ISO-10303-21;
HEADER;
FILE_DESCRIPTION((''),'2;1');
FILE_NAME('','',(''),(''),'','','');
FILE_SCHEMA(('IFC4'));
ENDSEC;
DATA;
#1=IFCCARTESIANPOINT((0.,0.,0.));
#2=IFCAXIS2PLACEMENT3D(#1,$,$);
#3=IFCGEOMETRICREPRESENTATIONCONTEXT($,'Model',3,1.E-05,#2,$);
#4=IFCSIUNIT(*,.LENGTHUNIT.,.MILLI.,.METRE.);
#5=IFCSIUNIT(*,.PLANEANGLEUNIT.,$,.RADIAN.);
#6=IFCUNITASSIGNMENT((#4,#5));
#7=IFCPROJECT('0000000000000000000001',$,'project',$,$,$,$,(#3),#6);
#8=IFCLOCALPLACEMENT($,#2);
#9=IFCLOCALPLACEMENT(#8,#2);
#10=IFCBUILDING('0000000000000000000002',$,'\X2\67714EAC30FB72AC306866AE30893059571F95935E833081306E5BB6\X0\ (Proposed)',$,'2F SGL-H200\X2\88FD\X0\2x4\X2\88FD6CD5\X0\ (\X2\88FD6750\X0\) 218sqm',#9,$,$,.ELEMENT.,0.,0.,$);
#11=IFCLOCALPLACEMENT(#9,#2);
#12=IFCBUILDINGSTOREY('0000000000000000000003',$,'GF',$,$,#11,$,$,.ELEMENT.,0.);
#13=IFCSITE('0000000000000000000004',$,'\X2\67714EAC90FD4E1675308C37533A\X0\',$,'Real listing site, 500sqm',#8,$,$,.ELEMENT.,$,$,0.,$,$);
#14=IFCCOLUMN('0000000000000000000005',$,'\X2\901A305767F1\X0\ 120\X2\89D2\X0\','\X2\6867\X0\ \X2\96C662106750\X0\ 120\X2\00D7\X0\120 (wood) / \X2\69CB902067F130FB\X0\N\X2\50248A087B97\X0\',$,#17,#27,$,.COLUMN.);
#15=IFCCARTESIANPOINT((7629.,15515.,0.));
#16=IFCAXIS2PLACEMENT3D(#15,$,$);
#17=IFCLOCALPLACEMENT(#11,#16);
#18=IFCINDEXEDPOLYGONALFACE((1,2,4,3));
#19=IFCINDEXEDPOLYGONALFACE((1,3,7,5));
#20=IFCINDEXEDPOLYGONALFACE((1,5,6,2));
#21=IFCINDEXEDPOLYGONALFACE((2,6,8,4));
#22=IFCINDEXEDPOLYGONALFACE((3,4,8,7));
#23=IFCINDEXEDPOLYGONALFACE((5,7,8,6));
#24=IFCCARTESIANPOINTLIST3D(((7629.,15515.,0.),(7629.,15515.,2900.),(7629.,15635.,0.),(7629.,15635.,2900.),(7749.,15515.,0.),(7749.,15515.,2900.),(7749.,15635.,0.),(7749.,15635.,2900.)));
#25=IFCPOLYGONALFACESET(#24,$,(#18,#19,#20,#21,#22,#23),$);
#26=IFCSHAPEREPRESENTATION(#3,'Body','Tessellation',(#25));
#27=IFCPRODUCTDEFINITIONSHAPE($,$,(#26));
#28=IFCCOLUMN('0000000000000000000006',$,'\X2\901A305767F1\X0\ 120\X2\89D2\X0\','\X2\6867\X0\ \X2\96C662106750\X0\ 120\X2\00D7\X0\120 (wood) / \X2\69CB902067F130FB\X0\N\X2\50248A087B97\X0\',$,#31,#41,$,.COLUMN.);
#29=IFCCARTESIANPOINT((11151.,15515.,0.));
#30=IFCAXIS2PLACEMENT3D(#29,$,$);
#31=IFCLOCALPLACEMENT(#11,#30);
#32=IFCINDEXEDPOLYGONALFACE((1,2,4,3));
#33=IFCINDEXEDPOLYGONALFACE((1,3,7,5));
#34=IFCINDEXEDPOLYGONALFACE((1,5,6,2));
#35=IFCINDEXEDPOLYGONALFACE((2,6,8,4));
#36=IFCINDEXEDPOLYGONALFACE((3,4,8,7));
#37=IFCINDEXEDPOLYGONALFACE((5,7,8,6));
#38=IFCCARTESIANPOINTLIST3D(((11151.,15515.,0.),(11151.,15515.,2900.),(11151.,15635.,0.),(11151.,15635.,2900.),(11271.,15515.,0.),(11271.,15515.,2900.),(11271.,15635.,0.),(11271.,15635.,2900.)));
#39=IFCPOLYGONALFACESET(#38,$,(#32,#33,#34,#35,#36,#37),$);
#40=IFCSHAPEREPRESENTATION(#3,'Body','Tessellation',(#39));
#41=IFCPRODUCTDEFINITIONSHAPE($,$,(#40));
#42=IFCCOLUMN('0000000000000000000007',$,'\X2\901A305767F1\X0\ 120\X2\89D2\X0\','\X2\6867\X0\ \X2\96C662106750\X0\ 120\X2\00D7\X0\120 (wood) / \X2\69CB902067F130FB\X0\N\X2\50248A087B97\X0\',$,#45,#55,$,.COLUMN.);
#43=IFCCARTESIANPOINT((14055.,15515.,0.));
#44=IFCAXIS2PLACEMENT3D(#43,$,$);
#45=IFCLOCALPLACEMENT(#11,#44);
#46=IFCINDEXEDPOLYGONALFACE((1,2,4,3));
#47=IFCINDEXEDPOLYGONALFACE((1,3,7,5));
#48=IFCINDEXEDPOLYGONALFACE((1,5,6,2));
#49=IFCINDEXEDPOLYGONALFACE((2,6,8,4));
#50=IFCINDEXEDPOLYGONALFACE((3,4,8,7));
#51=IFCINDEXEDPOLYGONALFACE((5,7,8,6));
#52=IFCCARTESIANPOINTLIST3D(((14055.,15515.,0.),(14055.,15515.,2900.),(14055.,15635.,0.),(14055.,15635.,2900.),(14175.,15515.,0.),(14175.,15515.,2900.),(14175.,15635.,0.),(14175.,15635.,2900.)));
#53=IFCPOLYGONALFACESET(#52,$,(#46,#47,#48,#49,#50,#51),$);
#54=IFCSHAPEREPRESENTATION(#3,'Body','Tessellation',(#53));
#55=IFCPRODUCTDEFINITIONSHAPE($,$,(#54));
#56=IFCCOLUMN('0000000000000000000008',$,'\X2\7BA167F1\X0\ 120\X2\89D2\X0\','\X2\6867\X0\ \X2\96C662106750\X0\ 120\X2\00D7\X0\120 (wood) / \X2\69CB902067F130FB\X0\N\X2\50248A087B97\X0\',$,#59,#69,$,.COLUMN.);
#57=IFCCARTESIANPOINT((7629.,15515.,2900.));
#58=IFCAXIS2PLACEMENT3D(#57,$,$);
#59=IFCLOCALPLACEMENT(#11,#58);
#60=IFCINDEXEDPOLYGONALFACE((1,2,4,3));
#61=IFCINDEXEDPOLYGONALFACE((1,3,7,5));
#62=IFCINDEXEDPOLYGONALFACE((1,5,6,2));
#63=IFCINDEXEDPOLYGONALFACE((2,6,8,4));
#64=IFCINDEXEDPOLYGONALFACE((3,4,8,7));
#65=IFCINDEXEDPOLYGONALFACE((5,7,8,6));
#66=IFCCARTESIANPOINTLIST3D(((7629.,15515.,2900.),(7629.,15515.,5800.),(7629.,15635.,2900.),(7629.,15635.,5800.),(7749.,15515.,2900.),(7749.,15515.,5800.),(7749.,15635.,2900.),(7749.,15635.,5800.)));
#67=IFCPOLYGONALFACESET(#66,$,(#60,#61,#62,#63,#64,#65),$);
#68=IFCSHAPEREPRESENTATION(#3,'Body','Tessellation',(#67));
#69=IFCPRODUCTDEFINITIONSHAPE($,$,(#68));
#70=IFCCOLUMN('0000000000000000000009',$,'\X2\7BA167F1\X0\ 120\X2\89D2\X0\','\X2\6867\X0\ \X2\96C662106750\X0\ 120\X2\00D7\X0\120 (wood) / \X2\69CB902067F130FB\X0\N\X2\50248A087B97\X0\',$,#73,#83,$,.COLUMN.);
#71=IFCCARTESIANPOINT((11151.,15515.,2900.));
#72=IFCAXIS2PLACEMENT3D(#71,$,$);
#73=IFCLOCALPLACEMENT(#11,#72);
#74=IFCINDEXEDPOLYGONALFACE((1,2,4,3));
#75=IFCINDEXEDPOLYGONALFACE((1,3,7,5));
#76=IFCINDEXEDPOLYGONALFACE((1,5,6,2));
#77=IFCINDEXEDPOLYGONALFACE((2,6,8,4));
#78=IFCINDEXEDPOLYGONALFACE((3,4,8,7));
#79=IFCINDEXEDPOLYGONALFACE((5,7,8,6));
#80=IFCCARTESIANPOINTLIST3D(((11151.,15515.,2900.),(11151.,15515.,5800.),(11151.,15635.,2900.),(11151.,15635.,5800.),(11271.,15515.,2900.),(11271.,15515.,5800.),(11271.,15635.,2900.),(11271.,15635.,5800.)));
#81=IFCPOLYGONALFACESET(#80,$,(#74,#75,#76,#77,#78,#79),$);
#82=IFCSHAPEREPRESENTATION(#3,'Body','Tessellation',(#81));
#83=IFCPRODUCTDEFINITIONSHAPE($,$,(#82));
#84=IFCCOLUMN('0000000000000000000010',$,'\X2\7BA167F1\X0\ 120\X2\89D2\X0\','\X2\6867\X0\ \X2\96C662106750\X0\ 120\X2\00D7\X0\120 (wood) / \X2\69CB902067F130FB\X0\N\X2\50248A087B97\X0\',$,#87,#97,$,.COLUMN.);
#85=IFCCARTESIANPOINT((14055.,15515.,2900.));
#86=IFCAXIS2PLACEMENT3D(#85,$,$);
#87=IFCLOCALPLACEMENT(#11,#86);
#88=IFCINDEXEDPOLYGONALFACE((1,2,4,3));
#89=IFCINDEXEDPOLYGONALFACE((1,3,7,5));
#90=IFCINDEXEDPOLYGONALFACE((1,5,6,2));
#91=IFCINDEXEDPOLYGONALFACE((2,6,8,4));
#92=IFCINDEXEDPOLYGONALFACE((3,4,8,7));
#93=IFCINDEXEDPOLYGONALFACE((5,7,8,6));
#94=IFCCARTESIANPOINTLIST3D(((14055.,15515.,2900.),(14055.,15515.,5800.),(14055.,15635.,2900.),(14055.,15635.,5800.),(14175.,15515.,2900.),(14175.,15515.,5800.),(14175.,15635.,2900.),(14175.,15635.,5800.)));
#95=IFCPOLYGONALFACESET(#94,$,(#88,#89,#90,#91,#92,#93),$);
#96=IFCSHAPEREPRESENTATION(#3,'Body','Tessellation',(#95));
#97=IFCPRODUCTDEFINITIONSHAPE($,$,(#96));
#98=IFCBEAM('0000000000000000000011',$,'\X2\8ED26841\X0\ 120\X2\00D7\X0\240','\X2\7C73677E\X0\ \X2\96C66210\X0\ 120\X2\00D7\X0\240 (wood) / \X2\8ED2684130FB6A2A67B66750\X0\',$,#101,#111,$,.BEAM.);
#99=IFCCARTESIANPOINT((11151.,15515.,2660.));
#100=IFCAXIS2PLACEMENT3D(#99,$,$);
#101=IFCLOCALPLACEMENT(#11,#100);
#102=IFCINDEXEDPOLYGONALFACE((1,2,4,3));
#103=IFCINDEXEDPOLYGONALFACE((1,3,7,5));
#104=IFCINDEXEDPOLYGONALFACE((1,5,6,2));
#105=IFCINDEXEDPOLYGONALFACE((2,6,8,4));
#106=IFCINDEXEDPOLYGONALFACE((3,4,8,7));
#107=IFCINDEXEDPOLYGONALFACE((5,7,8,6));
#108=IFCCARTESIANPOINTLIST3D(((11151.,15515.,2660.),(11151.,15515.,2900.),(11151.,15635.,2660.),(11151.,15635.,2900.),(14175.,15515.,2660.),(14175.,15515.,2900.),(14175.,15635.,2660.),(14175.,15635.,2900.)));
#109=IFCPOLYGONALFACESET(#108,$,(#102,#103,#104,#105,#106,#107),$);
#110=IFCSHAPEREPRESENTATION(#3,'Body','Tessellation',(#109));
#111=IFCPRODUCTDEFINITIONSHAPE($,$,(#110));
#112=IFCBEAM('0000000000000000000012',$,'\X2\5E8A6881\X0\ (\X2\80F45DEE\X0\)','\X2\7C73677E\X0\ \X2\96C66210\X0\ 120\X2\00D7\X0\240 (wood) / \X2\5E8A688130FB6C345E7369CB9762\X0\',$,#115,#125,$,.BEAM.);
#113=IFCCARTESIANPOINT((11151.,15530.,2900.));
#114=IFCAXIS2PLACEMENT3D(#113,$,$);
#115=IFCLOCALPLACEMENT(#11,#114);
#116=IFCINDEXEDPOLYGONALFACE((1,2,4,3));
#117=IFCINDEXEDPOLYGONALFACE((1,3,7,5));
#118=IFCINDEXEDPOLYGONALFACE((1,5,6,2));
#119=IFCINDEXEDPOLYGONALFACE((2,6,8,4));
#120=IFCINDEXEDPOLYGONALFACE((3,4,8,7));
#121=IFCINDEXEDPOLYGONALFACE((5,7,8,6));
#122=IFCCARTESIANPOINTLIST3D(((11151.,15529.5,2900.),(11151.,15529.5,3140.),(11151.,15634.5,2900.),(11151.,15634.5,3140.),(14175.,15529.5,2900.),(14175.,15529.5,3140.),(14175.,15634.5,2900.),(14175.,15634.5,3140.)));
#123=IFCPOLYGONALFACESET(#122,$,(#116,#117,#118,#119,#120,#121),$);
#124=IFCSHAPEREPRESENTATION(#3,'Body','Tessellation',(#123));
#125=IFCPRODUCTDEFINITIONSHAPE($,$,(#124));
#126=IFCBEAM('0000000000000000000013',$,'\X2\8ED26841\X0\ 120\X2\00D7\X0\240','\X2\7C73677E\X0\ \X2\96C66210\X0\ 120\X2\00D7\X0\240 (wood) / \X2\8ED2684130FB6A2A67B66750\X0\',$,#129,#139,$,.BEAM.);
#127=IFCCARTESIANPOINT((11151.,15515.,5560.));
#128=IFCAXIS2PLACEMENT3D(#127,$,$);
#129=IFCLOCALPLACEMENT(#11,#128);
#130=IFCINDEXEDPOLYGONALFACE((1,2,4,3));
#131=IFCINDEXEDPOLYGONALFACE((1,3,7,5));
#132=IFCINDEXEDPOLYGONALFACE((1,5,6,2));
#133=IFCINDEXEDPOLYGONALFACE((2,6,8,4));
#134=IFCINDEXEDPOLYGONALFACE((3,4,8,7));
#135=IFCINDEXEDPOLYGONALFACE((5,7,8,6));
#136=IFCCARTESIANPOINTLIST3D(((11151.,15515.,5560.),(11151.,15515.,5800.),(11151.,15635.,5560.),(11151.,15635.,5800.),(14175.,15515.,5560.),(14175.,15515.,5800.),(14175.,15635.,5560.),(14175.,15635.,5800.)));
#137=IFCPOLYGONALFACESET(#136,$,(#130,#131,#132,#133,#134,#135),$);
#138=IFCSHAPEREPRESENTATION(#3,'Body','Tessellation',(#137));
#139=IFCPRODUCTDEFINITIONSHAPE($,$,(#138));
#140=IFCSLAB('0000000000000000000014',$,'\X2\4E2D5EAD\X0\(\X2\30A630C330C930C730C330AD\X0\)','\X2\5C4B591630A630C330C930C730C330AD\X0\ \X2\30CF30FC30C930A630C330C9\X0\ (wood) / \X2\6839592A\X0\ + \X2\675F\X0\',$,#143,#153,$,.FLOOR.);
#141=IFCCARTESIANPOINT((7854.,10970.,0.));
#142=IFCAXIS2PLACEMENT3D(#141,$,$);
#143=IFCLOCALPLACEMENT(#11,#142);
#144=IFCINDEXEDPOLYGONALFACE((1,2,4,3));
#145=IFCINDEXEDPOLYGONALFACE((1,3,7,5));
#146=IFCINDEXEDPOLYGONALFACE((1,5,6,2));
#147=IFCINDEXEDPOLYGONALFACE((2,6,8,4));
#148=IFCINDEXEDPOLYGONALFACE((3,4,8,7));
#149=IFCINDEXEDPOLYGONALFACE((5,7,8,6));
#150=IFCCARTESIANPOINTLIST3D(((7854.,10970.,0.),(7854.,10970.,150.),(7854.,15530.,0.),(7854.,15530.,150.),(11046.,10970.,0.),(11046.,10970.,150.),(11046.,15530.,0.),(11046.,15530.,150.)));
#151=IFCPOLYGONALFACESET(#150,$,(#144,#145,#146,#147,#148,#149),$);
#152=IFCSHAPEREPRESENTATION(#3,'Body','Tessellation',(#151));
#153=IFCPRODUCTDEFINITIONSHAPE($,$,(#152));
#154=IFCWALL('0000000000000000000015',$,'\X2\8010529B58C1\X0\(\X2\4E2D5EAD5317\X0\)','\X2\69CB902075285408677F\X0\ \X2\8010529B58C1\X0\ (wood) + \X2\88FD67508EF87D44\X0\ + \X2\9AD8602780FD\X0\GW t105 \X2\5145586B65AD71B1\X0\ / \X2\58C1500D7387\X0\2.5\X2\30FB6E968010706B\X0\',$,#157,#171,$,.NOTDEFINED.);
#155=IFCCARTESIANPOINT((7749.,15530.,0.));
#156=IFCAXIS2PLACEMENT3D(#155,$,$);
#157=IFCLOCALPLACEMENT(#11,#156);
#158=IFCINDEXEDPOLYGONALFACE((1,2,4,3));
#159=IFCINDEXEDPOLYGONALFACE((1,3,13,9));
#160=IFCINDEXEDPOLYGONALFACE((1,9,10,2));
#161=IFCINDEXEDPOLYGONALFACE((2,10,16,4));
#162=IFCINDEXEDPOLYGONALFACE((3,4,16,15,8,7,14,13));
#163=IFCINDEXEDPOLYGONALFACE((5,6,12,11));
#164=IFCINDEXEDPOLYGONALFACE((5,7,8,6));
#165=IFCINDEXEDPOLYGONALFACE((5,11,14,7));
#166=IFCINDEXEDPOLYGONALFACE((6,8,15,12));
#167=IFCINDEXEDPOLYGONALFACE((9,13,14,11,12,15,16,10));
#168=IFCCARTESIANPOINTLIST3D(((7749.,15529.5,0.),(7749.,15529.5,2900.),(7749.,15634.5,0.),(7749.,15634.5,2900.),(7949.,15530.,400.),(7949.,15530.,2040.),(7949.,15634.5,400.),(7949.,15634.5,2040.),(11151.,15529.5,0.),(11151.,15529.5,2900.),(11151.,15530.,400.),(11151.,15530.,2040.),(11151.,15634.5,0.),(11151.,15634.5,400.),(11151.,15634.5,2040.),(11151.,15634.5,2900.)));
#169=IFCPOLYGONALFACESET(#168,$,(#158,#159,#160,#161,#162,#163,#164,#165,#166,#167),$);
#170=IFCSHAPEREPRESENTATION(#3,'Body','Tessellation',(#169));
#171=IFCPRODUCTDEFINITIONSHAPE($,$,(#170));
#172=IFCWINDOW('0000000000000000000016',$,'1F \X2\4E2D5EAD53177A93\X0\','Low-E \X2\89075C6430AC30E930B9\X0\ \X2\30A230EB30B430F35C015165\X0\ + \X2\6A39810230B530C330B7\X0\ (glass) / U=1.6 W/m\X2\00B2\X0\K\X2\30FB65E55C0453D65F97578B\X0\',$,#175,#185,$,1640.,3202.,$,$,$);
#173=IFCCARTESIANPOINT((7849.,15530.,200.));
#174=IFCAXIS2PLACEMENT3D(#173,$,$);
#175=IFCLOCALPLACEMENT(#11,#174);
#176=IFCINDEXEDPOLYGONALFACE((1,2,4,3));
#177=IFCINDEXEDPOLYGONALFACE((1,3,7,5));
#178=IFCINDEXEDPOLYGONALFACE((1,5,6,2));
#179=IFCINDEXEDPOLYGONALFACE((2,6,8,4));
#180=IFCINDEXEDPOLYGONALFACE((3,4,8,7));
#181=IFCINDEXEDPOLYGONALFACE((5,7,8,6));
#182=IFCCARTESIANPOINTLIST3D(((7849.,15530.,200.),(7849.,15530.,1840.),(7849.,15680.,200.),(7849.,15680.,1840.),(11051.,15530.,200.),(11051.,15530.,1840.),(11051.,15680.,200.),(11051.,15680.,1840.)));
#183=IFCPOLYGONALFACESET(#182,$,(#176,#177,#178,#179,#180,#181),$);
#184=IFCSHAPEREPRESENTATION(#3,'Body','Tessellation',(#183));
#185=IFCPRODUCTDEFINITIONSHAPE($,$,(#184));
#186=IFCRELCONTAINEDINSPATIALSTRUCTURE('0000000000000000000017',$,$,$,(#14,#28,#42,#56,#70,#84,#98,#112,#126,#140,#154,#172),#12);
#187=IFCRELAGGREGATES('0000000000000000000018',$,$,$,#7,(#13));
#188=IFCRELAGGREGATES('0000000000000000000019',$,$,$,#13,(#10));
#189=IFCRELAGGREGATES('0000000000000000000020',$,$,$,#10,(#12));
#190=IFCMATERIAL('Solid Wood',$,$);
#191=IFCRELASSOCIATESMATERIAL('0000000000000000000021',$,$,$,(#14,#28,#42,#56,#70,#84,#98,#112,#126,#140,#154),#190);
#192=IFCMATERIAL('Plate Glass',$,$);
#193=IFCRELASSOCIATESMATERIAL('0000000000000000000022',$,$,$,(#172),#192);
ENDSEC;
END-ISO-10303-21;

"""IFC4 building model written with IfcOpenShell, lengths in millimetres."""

from ifc_helpers import new_model, si_unit, frame, frame_2d, origin, place, context, project, spatial, rectangle, extrude, material, element, fill, save


model = new_model("IFC4")

# Units and contexts
model_context = context("Model", 3, precision=1e-05, world=origin())
ifc_project = project(units=[si_unit("LENGTHUNIT", "METRE", prefix="MILLI"), si_unit("PLANEANGLEUNIT", "RADIAN")], contexts=[model_context])

# Site, building, storey
site_placement = place(None, origin())
site = spatial("IfcSite", under=ifc_project, at=site_placement, Name="東京都世田谷区", ObjectType="Real listing site, 500sqm", CompositionType="ELEMENT", RefElevation=0.0)
building_placement = place(site_placement, origin())
building = spatial("IfcBuilding", under=site, at=building_placement, Name="東京・犬と暮らす土間広めの家 (Proposed)", ObjectType="2F SGL-H200製2x4製法 (製材) 218sqm", CompositionType="ELEMENT", ElevationOfRefHeight=0.0, ElevationOfTerrain=0.0)
storey_placement = place(building_placement, origin())
storey = spatial("IfcBuildingStorey", under=building, at=storey_placement, Name="GF", CompositionType="ELEMENT", Elevation=0.0)

# Columns
ifc_material_1 = material(Name="Solid Wood")
column_1_placement = place(storey_placement, frame((7629.0, 15515.0, 0.0)))
element("IfcColumn", 1, at=column_1_placement, inside=storey, material=ifc_material_1, Name="通し柱 120角", Description="桧 集成材 120×120 (wood) / 構造柱・N値計算", PredefinedType="COLUMN", context=model_context, shape_type="SweptSolid", body=[
    extrude(rectangle(XDim=120.0, YDim=120.0, at=frame_2d((60.0, 60.0))), frame((7629.0, 15515.0, 0.0)), (0.0, 0.0, 1.0), 2900.0),
])
column_2_placement = place(storey_placement, frame((11151.0, 15515.0, 0.0)))
element("IfcColumn", 2, at=column_2_placement, inside=storey, material=ifc_material_1, Name="通し柱 120角", Description="桧 集成材 120×120 (wood) / 構造柱・N値計算", PredefinedType="COLUMN", context=model_context, shape_type="SweptSolid", body=[
    extrude(rectangle(XDim=120.0, YDim=120.0, at=frame_2d((60.0, 60.0))), frame((11151.0, 15515.0, 0.0)), (0.0, 0.0, 1.0), 2900.0),
])
column_3_placement = place(storey_placement, frame((14055.0, 15515.0, 0.0)))
element("IfcColumn", 3, at=column_3_placement, inside=storey, material=ifc_material_1, Name="通し柱 120角", Description="桧 集成材 120×120 (wood) / 構造柱・N値計算", PredefinedType="COLUMN", context=model_context, shape_type="SweptSolid", body=[
    extrude(rectangle(XDim=120.0, YDim=120.0, at=frame_2d((60.0, 60.0))), frame((14055.0, 15515.0, 0.0)), (0.0, 0.0, 1.0), 2900.0),
])
column_4_placement = place(storey_placement, frame((7629.0, 15515.0, 2900.0)))
element("IfcColumn", 4, at=column_4_placement, inside=storey, material=ifc_material_1, Name="管柱 120角", Description="桧 集成材 120×120 (wood) / 構造柱・N値計算", PredefinedType="COLUMN", context=model_context, shape_type="SweptSolid", body=[
    extrude(rectangle(XDim=120.0, YDim=120.0, at=frame_2d((60.0, 60.0))), frame((7629.0, 15515.0, 2900.0)), (0.0, 0.0, 1.0), 2900.0),
])
column_5_placement = place(storey_placement, frame((11151.0, 15515.0, 2900.0)))
element("IfcColumn", 5, at=column_5_placement, inside=storey, material=ifc_material_1, Name="管柱 120角", Description="桧 集成材 120×120 (wood) / 構造柱・N値計算", PredefinedType="COLUMN", context=model_context, shape_type="SweptSolid", body=[
    extrude(rectangle(XDim=120.0, YDim=120.0, at=frame_2d((60.0, 60.0))), frame((11151.0, 15515.0, 2900.0)), (0.0, 0.0, 1.0), 2900.0),
])
column_6_placement = place(storey_placement, frame((14055.0, 15515.0, 2900.0)))
element("IfcColumn", 6, at=column_6_placement, inside=storey, material=ifc_material_1, Name="管柱 120角", Description="桧 集成材 120×120 (wood) / 構造柱・N値計算", PredefinedType="COLUMN", context=model_context, shape_type="SweptSolid", body=[
    extrude(rectangle(XDim=120.0, YDim=120.0, at=frame_2d((60.0, 60.0))), frame((14055.0, 15515.0, 2900.0)), (0.0, 0.0, 1.0), 2900.0),
])

# Beams
beam_1_placement = place(storey_placement, frame((11151.0, 15515.0, 2660.0)))
element("IfcBeam", 7, at=beam_1_placement, inside=storey, material=ifc_material_1, Name="軒桁 120×240", Description="米松 集成 120×240 (wood) / 軒桁・横架材", PredefinedType="BEAM", context=model_context, shape_type="SweptSolid", body=[
    extrude(rectangle(XDim=3024.0, YDim=120.0, at=frame_2d((1512.0, 60.0))), frame((11151.0, 15515.0, 2660.0)), (0.0, 0.0, 1.0), 240.0),
])
beam_2_placement = place(storey_placement, frame((11151.0, 15530.0, 2900.0)))
element("IfcBeam", 8, at=beam_2_placement, inside=storey, material=ifc_material_1, Name="床梁 (胴差)", Description="米松 集成 120×240 (wood) / 床梁・水平構面", PredefinedType="BEAM", context=model_context, shape_type="SweptSolid", body=[
    extrude(rectangle(XDim=3024.0, YDim=105.0, at=frame_2d((1512.0, 52.0))), frame((11151.0, 15530.0, 2900.0)), (0.0, 0.0, 1.0), 240.0),
])
beam_3_placement = place(storey_placement, frame((11151.0, 15515.0, 5560.0)))
element("IfcBeam", 9, at=beam_3_placement, inside=storey, material=ifc_material_1, Name="軒桁 120×240", Description="米松 集成 120×240 (wood) / 軒桁・横架材", PredefinedType="BEAM", context=model_context, shape_type="SweptSolid", body=[
    extrude(rectangle(XDim=3024.0, YDim=120.0, at=frame_2d((1512.0, 60.0))), frame((11151.0, 15515.0, 5560.0)), (0.0, 0.0, 1.0), 240.0),
])

# Slab
slab_placement = place(storey_placement, frame((7854.0, 10970.0, 0.0)))
element("IfcSlab", 10, at=slab_placement, inside=storey, material=ifc_material_1, Name="中庭(ウッドデッキ)", Description="屋外ウッドデッキ ハードウッド (wood) / 根太 + 束", PredefinedType="FLOOR", context=model_context, shape_type="SweptSolid", body=[
    extrude(rectangle(XDim=3192.0, YDim=4560.0, at=frame_2d((1596.0, 2280.0))), frame((7854.0, 10970.0, 0.0)), (0.0, 0.0, 1.0), 150.0),
])

# Wall, opening, window
wall_1_placement = place(storey_placement, frame((7749.0, 15530.0, 0.0)))
wall_1 = element("IfcWall", 11, at=wall_1_placement, inside=storey, material=ifc_material_1, Name="耐力壁(中庭北)", Description="構造用合板 耐力壁 (wood) + 製材軸組 + 高性能GW t105 充填断熱 / 壁倍率2.5・準耐火", PredefinedType="NOTDEFINED", context=model_context, shape_type="SweptSolid", body=[
    extrude(rectangle(XDim=3402.0, YDim=105.0, at=frame_2d((1701.0, 52.0))), frame((7749.0, 15530.0, 0.0)), (0.0, 0.0, 1.0), 2900.0),
])
opening_1_placement = place(storey_placement, frame((7849.0, 15530.0, 200.0)))
opening_1 = element("IfcOpeningElement", 12, at=opening_1_placement, cuts=wall_1, PredefinedType="NOTDEFINED", context=model_context, shape_type="SweptSolid", body=[
    extrude(rectangle(XDim=3202.0, YDim=150.0, at=frame_2d((1601.0, 75.0))), frame((7849.0, 15530.0, 200.0)), (0.0, 0.0, 1.0), 1640.0),
])
ifc_material_2 = material(Name="Plate Glass")
window_1_placement = place(storey_placement, frame((7849.0, 15530.0, 200.0)))
window_1 = element("IfcWindow", 13, at=window_1_placement, inside=storey, material=ifc_material_2, Name="1F 中庭北窓", Description="Low-E 複層ガラス アルゴン封入 + 樹脂サッシ (glass) / U=1.6 W/m²K・日射取得型", OverallHeight=1640.0, OverallWidth=3202.0, context=model_context, shape_type="SweptSolid", body=[
    extrude(rectangle(XDim=3202.0, YDim=150.0, at=frame_2d((1601.0, 75.0))), frame((7849.0, 15530.0, 200.0)), (0.0, 0.0, 1.0), 1640.0),
])
fill(opening_1, window_1)

save(model, "model.ifc")
